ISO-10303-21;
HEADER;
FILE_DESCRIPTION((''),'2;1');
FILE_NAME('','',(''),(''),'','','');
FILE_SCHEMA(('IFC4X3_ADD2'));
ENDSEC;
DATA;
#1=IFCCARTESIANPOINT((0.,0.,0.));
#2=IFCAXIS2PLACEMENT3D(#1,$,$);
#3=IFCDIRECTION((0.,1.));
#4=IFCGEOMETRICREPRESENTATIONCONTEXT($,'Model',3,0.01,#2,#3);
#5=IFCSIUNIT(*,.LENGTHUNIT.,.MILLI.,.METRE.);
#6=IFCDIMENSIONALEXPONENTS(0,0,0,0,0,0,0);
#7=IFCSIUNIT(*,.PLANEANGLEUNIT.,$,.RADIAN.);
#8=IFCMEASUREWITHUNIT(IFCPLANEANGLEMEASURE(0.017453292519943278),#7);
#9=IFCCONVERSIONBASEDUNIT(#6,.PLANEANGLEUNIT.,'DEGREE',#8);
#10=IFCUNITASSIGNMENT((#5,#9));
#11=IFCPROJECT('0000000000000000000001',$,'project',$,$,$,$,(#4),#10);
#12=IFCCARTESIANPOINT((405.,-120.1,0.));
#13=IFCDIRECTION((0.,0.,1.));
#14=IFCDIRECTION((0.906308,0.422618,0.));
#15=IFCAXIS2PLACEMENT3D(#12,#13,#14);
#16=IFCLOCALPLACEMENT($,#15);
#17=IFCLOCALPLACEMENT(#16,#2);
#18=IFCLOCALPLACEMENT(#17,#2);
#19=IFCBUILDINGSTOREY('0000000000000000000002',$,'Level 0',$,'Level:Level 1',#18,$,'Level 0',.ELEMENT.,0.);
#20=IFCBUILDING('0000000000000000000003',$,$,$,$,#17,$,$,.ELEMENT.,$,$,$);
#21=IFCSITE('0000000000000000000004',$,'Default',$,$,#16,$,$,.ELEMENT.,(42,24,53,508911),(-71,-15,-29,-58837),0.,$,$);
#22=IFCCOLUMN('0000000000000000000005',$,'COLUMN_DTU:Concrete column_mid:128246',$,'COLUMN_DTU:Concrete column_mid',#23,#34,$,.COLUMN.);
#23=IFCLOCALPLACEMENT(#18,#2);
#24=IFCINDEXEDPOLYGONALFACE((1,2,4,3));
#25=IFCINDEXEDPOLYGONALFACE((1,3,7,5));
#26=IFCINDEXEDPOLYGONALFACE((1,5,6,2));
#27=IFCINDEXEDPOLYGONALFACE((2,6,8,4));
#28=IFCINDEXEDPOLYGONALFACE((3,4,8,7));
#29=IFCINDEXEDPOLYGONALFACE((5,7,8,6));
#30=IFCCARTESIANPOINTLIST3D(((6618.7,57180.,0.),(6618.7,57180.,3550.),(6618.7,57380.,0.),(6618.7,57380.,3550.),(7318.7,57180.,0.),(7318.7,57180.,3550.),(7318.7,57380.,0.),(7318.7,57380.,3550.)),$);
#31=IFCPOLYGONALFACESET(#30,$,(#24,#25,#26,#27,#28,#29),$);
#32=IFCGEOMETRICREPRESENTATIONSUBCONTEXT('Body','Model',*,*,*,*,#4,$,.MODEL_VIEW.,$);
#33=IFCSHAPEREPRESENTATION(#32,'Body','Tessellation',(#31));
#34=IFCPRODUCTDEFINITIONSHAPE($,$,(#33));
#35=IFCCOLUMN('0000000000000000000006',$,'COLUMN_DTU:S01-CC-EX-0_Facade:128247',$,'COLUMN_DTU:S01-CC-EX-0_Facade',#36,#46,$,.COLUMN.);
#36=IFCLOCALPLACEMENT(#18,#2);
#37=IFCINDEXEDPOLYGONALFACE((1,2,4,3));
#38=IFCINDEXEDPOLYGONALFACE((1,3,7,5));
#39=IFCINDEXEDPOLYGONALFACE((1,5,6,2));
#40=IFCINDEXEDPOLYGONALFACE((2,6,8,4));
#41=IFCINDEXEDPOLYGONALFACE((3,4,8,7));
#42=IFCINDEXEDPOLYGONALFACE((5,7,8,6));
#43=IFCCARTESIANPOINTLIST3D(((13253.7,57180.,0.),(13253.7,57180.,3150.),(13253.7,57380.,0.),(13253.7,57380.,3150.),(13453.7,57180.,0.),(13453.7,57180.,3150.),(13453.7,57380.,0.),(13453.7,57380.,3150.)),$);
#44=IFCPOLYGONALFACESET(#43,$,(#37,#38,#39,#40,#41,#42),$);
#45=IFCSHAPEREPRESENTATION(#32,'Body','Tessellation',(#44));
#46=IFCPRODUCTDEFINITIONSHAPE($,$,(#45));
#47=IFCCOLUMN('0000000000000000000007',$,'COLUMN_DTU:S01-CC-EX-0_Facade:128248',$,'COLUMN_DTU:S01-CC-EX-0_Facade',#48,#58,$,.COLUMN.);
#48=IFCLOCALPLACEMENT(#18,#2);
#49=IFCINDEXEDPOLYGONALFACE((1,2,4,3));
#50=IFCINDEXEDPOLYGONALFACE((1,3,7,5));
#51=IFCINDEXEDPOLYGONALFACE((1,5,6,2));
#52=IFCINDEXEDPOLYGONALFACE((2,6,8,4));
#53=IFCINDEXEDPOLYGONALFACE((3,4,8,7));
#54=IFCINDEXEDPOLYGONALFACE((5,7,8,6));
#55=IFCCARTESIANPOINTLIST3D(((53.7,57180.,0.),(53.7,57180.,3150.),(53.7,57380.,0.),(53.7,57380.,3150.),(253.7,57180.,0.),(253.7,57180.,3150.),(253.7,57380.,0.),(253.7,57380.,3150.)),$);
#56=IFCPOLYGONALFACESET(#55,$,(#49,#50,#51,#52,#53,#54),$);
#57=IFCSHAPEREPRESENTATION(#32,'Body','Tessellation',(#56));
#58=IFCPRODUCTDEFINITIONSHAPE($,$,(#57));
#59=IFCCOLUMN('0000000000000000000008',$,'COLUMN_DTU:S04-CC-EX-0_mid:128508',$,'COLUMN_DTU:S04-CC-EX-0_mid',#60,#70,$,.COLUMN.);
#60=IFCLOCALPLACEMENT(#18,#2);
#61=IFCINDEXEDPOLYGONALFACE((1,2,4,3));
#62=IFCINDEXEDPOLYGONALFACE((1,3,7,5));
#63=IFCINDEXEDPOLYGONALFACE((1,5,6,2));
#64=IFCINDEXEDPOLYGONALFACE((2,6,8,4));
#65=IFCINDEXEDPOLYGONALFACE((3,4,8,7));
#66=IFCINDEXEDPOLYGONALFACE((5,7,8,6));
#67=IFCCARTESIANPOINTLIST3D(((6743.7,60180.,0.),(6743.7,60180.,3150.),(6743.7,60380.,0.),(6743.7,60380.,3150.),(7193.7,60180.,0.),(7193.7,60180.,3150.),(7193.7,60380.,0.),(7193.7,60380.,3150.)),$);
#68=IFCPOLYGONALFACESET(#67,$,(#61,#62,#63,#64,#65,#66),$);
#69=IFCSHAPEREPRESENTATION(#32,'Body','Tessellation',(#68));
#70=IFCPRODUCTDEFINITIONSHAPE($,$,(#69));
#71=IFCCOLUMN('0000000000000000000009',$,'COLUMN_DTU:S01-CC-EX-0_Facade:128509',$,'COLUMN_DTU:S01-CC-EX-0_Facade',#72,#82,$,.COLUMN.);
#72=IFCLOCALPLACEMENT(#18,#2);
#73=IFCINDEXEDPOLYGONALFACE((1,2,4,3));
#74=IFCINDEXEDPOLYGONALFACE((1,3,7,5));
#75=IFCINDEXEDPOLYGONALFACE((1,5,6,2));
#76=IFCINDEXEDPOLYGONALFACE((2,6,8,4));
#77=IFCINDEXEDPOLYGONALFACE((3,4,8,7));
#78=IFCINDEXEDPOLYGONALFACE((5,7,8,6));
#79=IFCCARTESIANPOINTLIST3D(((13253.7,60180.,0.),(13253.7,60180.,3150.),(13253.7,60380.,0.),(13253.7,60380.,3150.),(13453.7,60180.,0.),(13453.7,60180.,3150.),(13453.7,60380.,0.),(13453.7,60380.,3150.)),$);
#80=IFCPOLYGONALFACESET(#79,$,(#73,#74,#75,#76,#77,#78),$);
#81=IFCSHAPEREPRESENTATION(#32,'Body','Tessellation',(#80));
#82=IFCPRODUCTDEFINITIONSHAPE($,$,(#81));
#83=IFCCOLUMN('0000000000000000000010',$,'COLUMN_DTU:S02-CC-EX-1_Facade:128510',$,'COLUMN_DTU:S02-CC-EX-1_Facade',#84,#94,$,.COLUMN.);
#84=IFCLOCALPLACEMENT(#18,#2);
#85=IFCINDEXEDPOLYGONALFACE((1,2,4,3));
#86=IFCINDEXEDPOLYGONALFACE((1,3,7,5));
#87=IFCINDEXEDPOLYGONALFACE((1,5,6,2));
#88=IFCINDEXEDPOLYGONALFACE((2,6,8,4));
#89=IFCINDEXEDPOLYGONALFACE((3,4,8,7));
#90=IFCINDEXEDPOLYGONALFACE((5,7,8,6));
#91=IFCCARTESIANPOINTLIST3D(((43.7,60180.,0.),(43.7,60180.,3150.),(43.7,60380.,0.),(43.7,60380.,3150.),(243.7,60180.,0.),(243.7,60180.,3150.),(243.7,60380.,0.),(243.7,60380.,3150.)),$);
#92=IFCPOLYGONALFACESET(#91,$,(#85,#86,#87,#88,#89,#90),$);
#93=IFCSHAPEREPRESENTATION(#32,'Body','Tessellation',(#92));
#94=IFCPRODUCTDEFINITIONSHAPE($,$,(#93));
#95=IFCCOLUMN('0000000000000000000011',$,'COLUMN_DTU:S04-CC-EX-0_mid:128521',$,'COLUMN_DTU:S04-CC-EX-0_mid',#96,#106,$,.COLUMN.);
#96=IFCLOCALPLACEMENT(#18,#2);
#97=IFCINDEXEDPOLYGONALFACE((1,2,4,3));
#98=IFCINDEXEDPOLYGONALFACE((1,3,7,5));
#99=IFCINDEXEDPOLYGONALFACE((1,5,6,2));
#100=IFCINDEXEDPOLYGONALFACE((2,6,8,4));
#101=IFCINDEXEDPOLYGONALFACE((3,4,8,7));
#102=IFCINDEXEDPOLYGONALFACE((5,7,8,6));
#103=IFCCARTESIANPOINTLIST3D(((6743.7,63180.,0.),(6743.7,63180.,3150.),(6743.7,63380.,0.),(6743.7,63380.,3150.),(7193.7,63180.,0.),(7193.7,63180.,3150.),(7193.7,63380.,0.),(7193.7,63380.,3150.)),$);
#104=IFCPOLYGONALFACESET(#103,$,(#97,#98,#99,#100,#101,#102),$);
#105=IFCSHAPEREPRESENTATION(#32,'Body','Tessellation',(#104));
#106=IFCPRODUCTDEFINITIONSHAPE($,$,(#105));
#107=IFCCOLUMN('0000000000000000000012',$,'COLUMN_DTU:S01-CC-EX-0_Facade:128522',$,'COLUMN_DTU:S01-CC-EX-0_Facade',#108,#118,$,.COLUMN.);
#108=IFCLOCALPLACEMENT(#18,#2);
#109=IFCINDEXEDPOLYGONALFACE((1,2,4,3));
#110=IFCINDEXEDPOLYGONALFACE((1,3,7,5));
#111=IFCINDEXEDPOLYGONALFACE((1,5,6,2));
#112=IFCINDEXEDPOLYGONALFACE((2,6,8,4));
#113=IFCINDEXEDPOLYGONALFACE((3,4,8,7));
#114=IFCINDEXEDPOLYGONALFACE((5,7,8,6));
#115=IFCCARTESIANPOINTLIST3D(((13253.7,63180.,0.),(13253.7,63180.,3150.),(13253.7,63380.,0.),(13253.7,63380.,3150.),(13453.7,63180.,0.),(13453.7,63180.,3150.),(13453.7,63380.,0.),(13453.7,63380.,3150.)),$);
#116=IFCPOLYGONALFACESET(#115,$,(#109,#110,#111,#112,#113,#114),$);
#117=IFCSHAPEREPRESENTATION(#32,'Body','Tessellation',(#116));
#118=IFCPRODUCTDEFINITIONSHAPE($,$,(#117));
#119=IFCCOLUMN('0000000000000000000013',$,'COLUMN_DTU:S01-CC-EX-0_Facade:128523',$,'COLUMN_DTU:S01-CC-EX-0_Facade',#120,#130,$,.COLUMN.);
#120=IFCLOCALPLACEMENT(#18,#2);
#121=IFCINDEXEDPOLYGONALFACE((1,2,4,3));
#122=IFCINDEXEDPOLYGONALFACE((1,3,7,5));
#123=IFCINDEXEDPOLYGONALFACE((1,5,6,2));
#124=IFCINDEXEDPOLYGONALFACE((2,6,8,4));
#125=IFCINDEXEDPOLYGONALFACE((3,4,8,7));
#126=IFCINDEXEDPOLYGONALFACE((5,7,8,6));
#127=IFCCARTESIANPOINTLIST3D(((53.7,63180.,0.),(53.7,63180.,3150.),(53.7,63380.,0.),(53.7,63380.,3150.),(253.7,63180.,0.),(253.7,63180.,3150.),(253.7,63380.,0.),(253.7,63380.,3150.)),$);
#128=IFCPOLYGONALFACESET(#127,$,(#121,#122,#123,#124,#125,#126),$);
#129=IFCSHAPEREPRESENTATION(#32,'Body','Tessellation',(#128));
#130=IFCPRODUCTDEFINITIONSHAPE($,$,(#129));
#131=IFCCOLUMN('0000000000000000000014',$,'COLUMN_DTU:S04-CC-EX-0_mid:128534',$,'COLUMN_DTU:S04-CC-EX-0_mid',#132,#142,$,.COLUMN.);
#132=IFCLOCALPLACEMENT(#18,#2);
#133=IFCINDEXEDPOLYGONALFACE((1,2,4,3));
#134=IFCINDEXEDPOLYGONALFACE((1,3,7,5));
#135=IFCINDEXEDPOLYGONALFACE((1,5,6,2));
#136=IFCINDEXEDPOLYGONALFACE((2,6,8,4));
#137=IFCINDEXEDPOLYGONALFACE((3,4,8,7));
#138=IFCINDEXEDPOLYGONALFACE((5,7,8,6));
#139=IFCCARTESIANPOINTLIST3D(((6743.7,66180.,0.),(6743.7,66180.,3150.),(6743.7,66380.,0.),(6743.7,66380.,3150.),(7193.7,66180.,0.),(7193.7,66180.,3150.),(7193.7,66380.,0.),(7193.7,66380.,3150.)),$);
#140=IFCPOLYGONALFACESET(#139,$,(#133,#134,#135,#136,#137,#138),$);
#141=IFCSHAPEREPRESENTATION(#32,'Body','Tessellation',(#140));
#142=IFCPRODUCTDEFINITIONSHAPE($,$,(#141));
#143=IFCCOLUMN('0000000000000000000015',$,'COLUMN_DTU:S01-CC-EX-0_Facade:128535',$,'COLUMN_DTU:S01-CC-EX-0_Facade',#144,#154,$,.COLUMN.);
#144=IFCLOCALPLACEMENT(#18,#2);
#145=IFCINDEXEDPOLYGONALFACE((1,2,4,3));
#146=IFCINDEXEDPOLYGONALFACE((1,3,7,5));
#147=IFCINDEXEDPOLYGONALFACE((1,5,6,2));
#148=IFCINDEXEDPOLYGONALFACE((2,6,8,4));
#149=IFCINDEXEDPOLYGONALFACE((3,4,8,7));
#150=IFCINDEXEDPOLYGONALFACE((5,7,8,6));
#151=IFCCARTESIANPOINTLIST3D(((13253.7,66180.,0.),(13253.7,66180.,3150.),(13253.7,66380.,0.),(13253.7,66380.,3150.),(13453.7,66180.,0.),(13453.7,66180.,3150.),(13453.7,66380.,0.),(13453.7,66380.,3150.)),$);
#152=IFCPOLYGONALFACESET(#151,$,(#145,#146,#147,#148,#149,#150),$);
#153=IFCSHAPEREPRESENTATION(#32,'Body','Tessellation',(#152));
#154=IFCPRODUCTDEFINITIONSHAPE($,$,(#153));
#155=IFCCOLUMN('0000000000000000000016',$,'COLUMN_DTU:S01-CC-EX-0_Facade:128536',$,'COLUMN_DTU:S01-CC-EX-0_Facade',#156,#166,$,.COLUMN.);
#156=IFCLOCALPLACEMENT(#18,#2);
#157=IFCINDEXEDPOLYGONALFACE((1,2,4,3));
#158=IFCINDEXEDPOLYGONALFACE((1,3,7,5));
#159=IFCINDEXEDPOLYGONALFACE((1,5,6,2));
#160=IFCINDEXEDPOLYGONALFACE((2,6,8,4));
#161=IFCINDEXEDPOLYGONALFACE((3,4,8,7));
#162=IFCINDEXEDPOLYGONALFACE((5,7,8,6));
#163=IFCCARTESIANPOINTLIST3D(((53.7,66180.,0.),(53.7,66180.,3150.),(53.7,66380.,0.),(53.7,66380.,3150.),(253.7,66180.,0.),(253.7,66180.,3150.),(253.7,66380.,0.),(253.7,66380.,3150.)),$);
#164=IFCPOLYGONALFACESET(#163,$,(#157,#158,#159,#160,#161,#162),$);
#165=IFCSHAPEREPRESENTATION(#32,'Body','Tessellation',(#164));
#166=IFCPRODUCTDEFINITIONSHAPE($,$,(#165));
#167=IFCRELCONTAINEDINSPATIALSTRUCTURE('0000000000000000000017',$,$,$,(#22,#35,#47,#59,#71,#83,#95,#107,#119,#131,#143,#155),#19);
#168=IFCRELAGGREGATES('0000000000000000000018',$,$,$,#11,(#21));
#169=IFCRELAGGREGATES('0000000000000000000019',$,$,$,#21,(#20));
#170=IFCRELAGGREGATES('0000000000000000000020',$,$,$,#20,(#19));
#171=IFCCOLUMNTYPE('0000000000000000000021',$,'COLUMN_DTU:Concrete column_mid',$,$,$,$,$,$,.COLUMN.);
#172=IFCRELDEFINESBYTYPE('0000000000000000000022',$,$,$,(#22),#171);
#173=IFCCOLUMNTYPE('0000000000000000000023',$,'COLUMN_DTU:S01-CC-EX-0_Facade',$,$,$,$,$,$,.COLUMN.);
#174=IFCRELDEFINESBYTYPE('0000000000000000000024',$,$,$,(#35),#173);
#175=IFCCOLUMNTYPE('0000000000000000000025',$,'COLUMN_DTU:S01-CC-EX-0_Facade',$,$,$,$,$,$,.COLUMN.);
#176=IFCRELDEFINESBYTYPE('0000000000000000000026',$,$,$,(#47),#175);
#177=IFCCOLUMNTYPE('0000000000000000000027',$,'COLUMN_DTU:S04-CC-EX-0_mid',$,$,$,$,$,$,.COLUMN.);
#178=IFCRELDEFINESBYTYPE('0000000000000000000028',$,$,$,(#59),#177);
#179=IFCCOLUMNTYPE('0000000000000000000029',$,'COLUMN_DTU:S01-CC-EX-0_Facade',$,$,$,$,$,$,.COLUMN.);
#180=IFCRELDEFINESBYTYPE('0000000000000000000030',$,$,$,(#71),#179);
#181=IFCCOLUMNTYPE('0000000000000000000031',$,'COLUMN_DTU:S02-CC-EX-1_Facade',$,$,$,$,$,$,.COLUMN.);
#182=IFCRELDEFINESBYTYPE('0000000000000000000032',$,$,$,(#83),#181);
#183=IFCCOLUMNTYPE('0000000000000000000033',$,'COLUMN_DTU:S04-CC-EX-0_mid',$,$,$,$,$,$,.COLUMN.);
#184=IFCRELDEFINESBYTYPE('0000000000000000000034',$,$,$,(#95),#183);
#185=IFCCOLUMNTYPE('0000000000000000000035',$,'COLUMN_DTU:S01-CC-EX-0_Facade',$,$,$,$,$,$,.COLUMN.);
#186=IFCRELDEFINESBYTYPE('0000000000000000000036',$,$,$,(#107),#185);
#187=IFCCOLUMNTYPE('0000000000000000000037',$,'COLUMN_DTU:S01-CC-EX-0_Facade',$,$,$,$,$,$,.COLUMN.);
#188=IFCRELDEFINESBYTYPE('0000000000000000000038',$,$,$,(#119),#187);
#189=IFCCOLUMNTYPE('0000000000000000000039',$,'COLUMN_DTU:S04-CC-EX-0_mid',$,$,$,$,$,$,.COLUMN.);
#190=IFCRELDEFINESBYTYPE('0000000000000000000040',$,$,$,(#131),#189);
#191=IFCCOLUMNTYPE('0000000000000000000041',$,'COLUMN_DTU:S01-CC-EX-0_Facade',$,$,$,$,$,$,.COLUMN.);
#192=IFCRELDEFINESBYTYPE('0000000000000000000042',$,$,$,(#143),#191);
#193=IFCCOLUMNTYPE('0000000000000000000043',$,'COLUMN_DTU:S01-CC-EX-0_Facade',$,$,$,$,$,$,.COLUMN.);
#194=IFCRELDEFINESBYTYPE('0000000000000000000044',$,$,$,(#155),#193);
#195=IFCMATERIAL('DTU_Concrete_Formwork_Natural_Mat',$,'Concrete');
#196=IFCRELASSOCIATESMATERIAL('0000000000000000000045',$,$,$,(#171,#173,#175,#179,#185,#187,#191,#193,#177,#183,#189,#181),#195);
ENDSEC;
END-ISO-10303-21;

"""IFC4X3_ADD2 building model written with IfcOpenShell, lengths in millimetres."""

from ifc_helpers import new_model, entity, si_unit, converted_unit, direction, frame, frame_2d, origin, place, context, subcontext, project, spatial, rectangle, extrude, source, transform, mapped, material, material_profile, profile_set, type_object, type_shapes, element, save


model = new_model("IFC4X3_ADD2")

# Units and contexts
model_context = context("Model", 3, precision=0.01, world=origin(), true_north=direction((0.0, 1.0)))
body_context = subcontext(model_context, "Body", "Model", "MODEL_VIEW")
ifc_project = project(units=[si_unit("LENGTHUNIT", "METRE", prefix="MILLI"), converted_unit("PLANEANGLEUNIT", "DEGREE", entity("IfcPlaneAngleMeasure", 0.017453292519943278), si_unit("PLANEANGLEUNIT", "RADIAN"), dimensions=[0, 0, 0, 0, 0, 0, 0])], contexts=[model_context])

# Site, building, storey
site_placement = place(None, frame((405.0, -120.1, 0.0), z_axis=(0.0, 0.0, 1.0), x_axis=(0.906308, 0.422618, 0.0)))
site = spatial("IfcSite", under=ifc_project, at=site_placement, Name="Default", CompositionType="ELEMENT", RefLatitude=(42, 24, 53, 508911), RefLongitude=(-71, -15, -29, -58837), RefElevation=0.0)
building_placement = place(site_placement, origin())
building = spatial("IfcBuilding", under=site, at=building_placement, CompositionType="ELEMENT")
storey_placement = place(building_placement, origin())
storey = spatial("IfcBuildingStorey", under=building, at=storey_placement, Name="Level 0", ObjectType="Level:Level 1", LongName="Level 0", CompositionType="ELEMENT", Elevation=0.0)

# Columns
ifc_material = material(Name="DTU_Concrete_Formwork_Natural_Mat", Category="Concrete")
ifc_material_profile_1 = material_profile(ifc_material, rectangle(XDim=3550.0, YDim=200.0, at=frame_2d((0.0, 0.0), x_axis=(1.0, 0.0))), Name="Concrete column_mid")
ifc_profile_set_1 = profile_set([ifc_material_profile_1], Name="Concrete column_mid")
column_type_1 = type_object("IfcColumnType", Name="COLUMN_DTU:Concrete column_mid", PredefinedType="COLUMN", material=ifc_profile_set_1)
shared_shape_1 = source(origin(), body_context, "Body", "SweptSolid", [
    extrude(rectangle(XDim=3550.0, YDim=200.0, at=frame_2d((0.0, 0.0), x_axis=(1.0, 0.0))), frame((6618.7, 57280.0, 1775.0), z_axis=(1.0, 0.0, 0.0), x_axis=(0.0, 0.0, 1.0)), (0.0, 0.0, 1.0), 700.0),
])
type_shapes(column_type_1, [shared_shape_1])
column_1_placement = place(storey_placement, origin())
element("IfcColumn", 1, at=column_1_placement, inside=storey, type_object=column_type_1, Name="COLUMN_DTU:Concrete column_mid:128246", ObjectType="COLUMN_DTU:Concrete column_mid", PredefinedType="COLUMN", context=body_context, shape_type="MappedRepresentation", body=[
    mapped(shared_shape_1, transform((0.0, 0.0, 0.0), scale=1.0)),
])
ifc_material_profile_2 = material_profile(ifc_material, rectangle(XDim=200.0, YDim=200.0, at=frame_2d((0.0, 0.0), x_axis=(1.0, 0.0))), Name="S01-CC-EX-0_Facade")
ifc_profile_set_2 = profile_set([ifc_material_profile_2], Name="S01-CC-EX-0_Facade")
column_type_2 = type_object("IfcColumnType", Name="COLUMN_DTU:S01-CC-EX-0_Facade", PredefinedType="COLUMN", material=ifc_profile_set_2)
shared_shape_2 = source(origin(), body_context, "Body", "SweptSolid", [
    extrude(rectangle(XDim=200.0, YDim=200.0, at=frame_2d((0.0, 0.0), x_axis=(1.0, 0.0))), frame((13353.7, 57280.0, 0.0), z_axis=(0.0, 0.0, 1.0), x_axis=(0.0, 1.0, 0.0)), (0.0, 0.0, 1.0), 3150.0),
])
type_shapes(column_type_2, [shared_shape_2])
column_2_placement = place(storey_placement, origin())
element("IfcColumn", 2, at=column_2_placement, inside=storey, type_object=column_type_2, Name="COLUMN_DTU:S01-CC-EX-0_Facade:128247", ObjectType="COLUMN_DTU:S01-CC-EX-0_Facade", PredefinedType="COLUMN", context=body_context, shape_type="MappedRepresentation", body=[
    mapped(shared_shape_2, transform((0.0, 0.0, 0.0), scale=1.0)),
])
column_type_3 = type_object("IfcColumnType", Name="COLUMN_DTU:S01-CC-EX-0_Facade", PredefinedType="COLUMN", material=ifc_profile_set_2)
shared_shape_3 = source(origin(), body_context, "Body", "SweptSolid", [
    extrude(rectangle(XDim=200.0, YDim=200.0, at=frame_2d((0.0, 0.0), x_axis=(1.0, 0.0))), frame((153.7, 57280.0, 0.0), z_axis=(0.0, 0.0, 1.0), x_axis=(0.0, 1.0, 0.0)), (0.0, 0.0, 1.0), 3150.0),
])
type_shapes(column_type_3, [shared_shape_3])
column_3_placement = place(storey_placement, origin())
element("IfcColumn", 3, at=column_3_placement, inside=storey, type_object=column_type_3, Name="COLUMN_DTU:S01-CC-EX-0_Facade:128248", ObjectType="COLUMN_DTU:S01-CC-EX-0_Facade", PredefinedType="COLUMN", context=body_context, shape_type="MappedRepresentation", body=[
    mapped(shared_shape_3, transform((0.0, 0.0, 0.0), scale=1.0)),
])
ifc_material_profile_3 = material_profile(ifc_material, rectangle(XDim=200.0, YDim=450.0, at=frame_2d((0.0, 0.0), x_axis=(1.0, 0.0))), Name="S04-CC-EX-0_mid")
ifc_profile_set_3 = profile_set([ifc_material_profile_3], Name="S04-CC-EX-0_mid")
column_type_4 = type_object("IfcColumnType", Name="COLUMN_DTU:S04-CC-EX-0_mid", PredefinedType="COLUMN", material=ifc_profile_set_3)
shared_shape_4 = source(origin(), body_context, "Body", "SweptSolid", [
    extrude(rectangle(XDim=200.0, YDim=450.0, at=frame_2d((0.0, 0.0), x_axis=(1.0, 0.0))), frame((6968.7, 60280.0, 0.0), z_axis=(0.0, 0.0, 1.0), x_axis=(0.0, 1.0, 0.0)), (0.0, 0.0, 1.0), 3150.0),
])
type_shapes(column_type_4, [shared_shape_4])
column_4_placement = place(storey_placement, origin())
element("IfcColumn", 4, at=column_4_placement, inside=storey, type_object=column_type_4, Name="COLUMN_DTU:S04-CC-EX-0_mid:128508", ObjectType="COLUMN_DTU:S04-CC-EX-0_mid", PredefinedType="COLUMN", context=body_context, shape_type="MappedRepresentation", body=[
    mapped(shared_shape_4, transform((0.0, 0.0, 0.0), scale=1.0)),
])
column_type_5 = type_object("IfcColumnType", Name="COLUMN_DTU:S01-CC-EX-0_Facade", PredefinedType="COLUMN", material=ifc_profile_set_2)
shared_shape_5 = source(origin(), body_context, "Body", "SweptSolid", [
    extrude(rectangle(XDim=200.0, YDim=200.0, at=frame_2d((0.0, 0.0), x_axis=(1.0, 0.0))), frame((13353.7, 60280.0, 0.0), z_axis=(0.0, 0.0, 1.0), x_axis=(0.0, 1.0, 0.0)), (0.0, 0.0, 1.0), 3150.0),
])
type_shapes(column_type_5, [shared_shape_5])
column_5_placement = place(storey_placement, origin())
element("IfcColumn", 5, at=column_5_placement, inside=storey, type_object=column_type_5, Name="COLUMN_DTU:S01-CC-EX-0_Facade:128509", ObjectType="COLUMN_DTU:S01-CC-EX-0_Facade", PredefinedType="COLUMN", context=body_context, shape_type="MappedRepresentation", body=[
    mapped(shared_shape_5, transform((0.0, 0.0, 0.0), scale=1.0)),
])
ifc_material_profile_4 = material_profile(ifc_material, rectangle(XDim=200.0, YDim=200.0, at=frame_2d((0.0, 0.0), x_axis=(1.0, 0.0))), Name="S02-CC-EX-1_Facade")
ifc_profile_set_4 = profile_set([ifc_material_profile_4], Name="S02-CC-EX-1_Facade")
column_type_6 = type_object("IfcColumnType", Name="COLUMN_DTU:S02-CC-EX-1_Facade", PredefinedType="COLUMN", material=ifc_profile_set_4)
shared_shape_6 = source(origin(), body_context, "Body", "SweptSolid", [
    extrude(rectangle(XDim=200.0, YDim=200.0, at=frame_2d((0.0, 0.0), x_axis=(1.0, 0.0))), frame((143.7, 60280.0, 0.0), z_axis=(0.0, 0.0, 1.0), x_axis=(0.0, 1.0, 0.0)), (0.0, 0.0, 1.0), 3150.0),
])
type_shapes(column_type_6, [shared_shape_6])
column_6_placement = place(storey_placement, origin())
element("IfcColumn", 6, at=column_6_placement, inside=storey, type_object=column_type_6, Name="COLUMN_DTU:S02-CC-EX-1_Facade:128510", ObjectType="COLUMN_DTU:S02-CC-EX-1_Facade", PredefinedType="COLUMN", context=body_context, shape_type="MappedRepresentation", body=[
    mapped(shared_shape_6, transform((0.0, 0.0, 0.0), scale=1.0)),
])
column_type_7 = type_object("IfcColumnType", Name="COLUMN_DTU:S04-CC-EX-0_mid", PredefinedType="COLUMN", material=ifc_profile_set_3)
shared_shape_7 = source(origin(), body_context, "Body", "SweptSolid", [
    extrude(rectangle(XDim=200.0, YDim=450.0, at=frame_2d((0.0, 0.0), x_axis=(1.0, 0.0))), frame((6968.7, 63280.0, 0.0), z_axis=(0.0, 0.0, 1.0), x_axis=(0.0, 1.0, 0.0)), (0.0, 0.0, 1.0), 3150.0),
])
type_shapes(column_type_7, [shared_shape_7])
column_7_placement = place(storey_placement, origin())
element("IfcColumn", 7, at=column_7_placement, inside=storey, type_object=column_type_7, Name="COLUMN_DTU:S04-CC-EX-0_mid:128521", ObjectType="COLUMN_DTU:S04-CC-EX-0_mid", PredefinedType="COLUMN", context=body_context, shape_type="MappedRepresentation", body=[
    mapped(shared_shape_7, transform((0.0, 0.0, 0.0), scale=1.0)),
])
column_type_8 = type_object("IfcColumnType", Name="COLUMN_DTU:S01-CC-EX-0_Facade", PredefinedType="COLUMN", material=ifc_profile_set_2)
shared_shape_8 = source(origin(), body_context, "Body", "SweptSolid", [
    extrude(rectangle(XDim=200.0, YDim=200.0, at=frame_2d((0.0, 0.0), x_axis=(1.0, 0.0))), frame((13353.7, 63280.0, 0.0), z_axis=(0.0, 0.0, 1.0), x_axis=(0.0, 1.0, 0.0)), (0.0, 0.0, 1.0), 3150.0),
])
type_shapes(column_type_8, [shared_shape_8])
column_8_placement = place(storey_placement, origin())
element("IfcColumn", 8, at=column_8_placement, inside=storey, type_object=column_type_8, Name="COLUMN_DTU:S01-CC-EX-0_Facade:128522", ObjectType="COLUMN_DTU:S01-CC-EX-0_Facade", PredefinedType="COLUMN", context=body_context, shape_type="MappedRepresentation", body=[
    mapped(shared_shape_8, transform((0.0, 0.0, 0.0), scale=1.0)),
])
column_type_9 = type_object("IfcColumnType", Name="COLUMN_DTU:S01-CC-EX-0_Facade", PredefinedType="COLUMN", material=ifc_profile_set_2)
shared_shape_9 = source(origin(), body_context, "Body", "SweptSolid", [
    extrude(rectangle(XDim=200.0, YDim=200.0, at=frame_2d((0.0, 0.0), x_axis=(1.0, 0.0))), frame((153.7, 63280.0, 0.0), z_axis=(0.0, 0.0, 1.0), x_axis=(0.0, 1.0, 0.0)), (0.0, 0.0, 1.0), 3150.0),
])
type_shapes(column_type_9, [shared_shape_9])
column_9_placement = place(storey_placement, origin())
element("IfcColumn", 9, at=column_9_placement, inside=storey, type_object=column_type_9, Name="COLUMN_DTU:S01-CC-EX-0_Facade:128523", ObjectType="COLUMN_DTU:S01-CC-EX-0_Facade", PredefinedType="COLUMN", context=body_context, shape_type="MappedRepresentation", body=[
    mapped(shared_shape_9, transform((0.0, 0.0, 0.0), scale=1.0)),
])
column_type_10 = type_object("IfcColumnType", Name="COLUMN_DTU:S04-CC-EX-0_mid", PredefinedType="COLUMN", material=ifc_profile_set_3)
shared_shape_10 = source(origin(), body_context, "Body", "SweptSolid", [
    extrude(rectangle(XDim=200.0, YDim=450.0, at=frame_2d((0.0, 0.0), x_axis=(1.0, 0.0))), frame((6968.7, 66280.0, 0.0), z_axis=(0.0, 0.0, 1.0), x_axis=(0.0, 1.0, 0.0)), (0.0, 0.0, 1.0), 3150.0),
])
type_shapes(column_type_10, [shared_shape_10])
column_10_placement = place(storey_placement, origin())
element("IfcColumn", 10, at=column_10_placement, inside=storey, type_object=column_type_10, Name="COLUMN_DTU:S04-CC-EX-0_mid:128534", ObjectType="COLUMN_DTU:S04-CC-EX-0_mid", PredefinedType="COLUMN", context=body_context, shape_type="MappedRepresentation", body=[
    mapped(shared_shape_10, transform((0.0, 0.0, 0.0), scale=1.0)),
])
column_type_11 = type_object("IfcColumnType", Name="COLUMN_DTU:S01-CC-EX-0_Facade", PredefinedType="COLUMN", material=ifc_profile_set_2)
shared_shape_11 = source(origin(), body_context, "Body", "SweptSolid", [
    extrude(rectangle(XDim=200.0, YDim=200.0, at=frame_2d((0.0, 0.0), x_axis=(1.0, 0.0))), frame((13353.7, 66280.0, 0.0), z_axis=(0.0, 0.0, 1.0), x_axis=(0.0, 1.0, 0.0)), (0.0, 0.0, 1.0), 3150.0),
])
type_shapes(column_type_11, [shared_shape_11])
column_11_placement = place(storey_placement, origin())
element("IfcColumn", 11, at=column_11_placement, inside=storey, type_object=column_type_11, Name="COLUMN_DTU:S01-CC-EX-0_Facade:128535", ObjectType="COLUMN_DTU:S01-CC-EX-0_Facade", PredefinedType="COLUMN", context=body_context, shape_type="MappedRepresentation", body=[
    mapped(shared_shape_11, transform((0.0, 0.0, 0.0), scale=1.0)),
])
column_type_12 = type_object("IfcColumnType", Name="COLUMN_DTU:S01-CC-EX-0_Facade", PredefinedType="COLUMN", material=ifc_profile_set_2)
shared_shape_12 = source(origin(), body_context, "Body", "SweptSolid", [
    extrude(rectangle(XDim=200.0, YDim=200.0, at=frame_2d((0.0, 0.0), x_axis=(1.0, 0.0))), frame((153.7, 66280.0, 0.0), z_axis=(0.0, 0.0, 1.0), x_axis=(0.0, 1.0, 0.0)), (0.0, 0.0, 1.0), 3150.0),
])
type_shapes(column_type_12, [shared_shape_12])
column_12_placement = place(storey_placement, origin())
element("IfcColumn", 12, at=column_12_placement, inside=storey, type_object=column_type_12, Name="COLUMN_DTU:S01-CC-EX-0_Facade:128536", ObjectType="COLUMN_DTU:S01-CC-EX-0_Facade", PredefinedType="COLUMN", context=body_context, shape_type="MappedRepresentation", body=[
    mapped(shared_shape_12, transform((0.0, 0.0, 0.0), scale=1.0)),
])

save(model, "model.ifc")
